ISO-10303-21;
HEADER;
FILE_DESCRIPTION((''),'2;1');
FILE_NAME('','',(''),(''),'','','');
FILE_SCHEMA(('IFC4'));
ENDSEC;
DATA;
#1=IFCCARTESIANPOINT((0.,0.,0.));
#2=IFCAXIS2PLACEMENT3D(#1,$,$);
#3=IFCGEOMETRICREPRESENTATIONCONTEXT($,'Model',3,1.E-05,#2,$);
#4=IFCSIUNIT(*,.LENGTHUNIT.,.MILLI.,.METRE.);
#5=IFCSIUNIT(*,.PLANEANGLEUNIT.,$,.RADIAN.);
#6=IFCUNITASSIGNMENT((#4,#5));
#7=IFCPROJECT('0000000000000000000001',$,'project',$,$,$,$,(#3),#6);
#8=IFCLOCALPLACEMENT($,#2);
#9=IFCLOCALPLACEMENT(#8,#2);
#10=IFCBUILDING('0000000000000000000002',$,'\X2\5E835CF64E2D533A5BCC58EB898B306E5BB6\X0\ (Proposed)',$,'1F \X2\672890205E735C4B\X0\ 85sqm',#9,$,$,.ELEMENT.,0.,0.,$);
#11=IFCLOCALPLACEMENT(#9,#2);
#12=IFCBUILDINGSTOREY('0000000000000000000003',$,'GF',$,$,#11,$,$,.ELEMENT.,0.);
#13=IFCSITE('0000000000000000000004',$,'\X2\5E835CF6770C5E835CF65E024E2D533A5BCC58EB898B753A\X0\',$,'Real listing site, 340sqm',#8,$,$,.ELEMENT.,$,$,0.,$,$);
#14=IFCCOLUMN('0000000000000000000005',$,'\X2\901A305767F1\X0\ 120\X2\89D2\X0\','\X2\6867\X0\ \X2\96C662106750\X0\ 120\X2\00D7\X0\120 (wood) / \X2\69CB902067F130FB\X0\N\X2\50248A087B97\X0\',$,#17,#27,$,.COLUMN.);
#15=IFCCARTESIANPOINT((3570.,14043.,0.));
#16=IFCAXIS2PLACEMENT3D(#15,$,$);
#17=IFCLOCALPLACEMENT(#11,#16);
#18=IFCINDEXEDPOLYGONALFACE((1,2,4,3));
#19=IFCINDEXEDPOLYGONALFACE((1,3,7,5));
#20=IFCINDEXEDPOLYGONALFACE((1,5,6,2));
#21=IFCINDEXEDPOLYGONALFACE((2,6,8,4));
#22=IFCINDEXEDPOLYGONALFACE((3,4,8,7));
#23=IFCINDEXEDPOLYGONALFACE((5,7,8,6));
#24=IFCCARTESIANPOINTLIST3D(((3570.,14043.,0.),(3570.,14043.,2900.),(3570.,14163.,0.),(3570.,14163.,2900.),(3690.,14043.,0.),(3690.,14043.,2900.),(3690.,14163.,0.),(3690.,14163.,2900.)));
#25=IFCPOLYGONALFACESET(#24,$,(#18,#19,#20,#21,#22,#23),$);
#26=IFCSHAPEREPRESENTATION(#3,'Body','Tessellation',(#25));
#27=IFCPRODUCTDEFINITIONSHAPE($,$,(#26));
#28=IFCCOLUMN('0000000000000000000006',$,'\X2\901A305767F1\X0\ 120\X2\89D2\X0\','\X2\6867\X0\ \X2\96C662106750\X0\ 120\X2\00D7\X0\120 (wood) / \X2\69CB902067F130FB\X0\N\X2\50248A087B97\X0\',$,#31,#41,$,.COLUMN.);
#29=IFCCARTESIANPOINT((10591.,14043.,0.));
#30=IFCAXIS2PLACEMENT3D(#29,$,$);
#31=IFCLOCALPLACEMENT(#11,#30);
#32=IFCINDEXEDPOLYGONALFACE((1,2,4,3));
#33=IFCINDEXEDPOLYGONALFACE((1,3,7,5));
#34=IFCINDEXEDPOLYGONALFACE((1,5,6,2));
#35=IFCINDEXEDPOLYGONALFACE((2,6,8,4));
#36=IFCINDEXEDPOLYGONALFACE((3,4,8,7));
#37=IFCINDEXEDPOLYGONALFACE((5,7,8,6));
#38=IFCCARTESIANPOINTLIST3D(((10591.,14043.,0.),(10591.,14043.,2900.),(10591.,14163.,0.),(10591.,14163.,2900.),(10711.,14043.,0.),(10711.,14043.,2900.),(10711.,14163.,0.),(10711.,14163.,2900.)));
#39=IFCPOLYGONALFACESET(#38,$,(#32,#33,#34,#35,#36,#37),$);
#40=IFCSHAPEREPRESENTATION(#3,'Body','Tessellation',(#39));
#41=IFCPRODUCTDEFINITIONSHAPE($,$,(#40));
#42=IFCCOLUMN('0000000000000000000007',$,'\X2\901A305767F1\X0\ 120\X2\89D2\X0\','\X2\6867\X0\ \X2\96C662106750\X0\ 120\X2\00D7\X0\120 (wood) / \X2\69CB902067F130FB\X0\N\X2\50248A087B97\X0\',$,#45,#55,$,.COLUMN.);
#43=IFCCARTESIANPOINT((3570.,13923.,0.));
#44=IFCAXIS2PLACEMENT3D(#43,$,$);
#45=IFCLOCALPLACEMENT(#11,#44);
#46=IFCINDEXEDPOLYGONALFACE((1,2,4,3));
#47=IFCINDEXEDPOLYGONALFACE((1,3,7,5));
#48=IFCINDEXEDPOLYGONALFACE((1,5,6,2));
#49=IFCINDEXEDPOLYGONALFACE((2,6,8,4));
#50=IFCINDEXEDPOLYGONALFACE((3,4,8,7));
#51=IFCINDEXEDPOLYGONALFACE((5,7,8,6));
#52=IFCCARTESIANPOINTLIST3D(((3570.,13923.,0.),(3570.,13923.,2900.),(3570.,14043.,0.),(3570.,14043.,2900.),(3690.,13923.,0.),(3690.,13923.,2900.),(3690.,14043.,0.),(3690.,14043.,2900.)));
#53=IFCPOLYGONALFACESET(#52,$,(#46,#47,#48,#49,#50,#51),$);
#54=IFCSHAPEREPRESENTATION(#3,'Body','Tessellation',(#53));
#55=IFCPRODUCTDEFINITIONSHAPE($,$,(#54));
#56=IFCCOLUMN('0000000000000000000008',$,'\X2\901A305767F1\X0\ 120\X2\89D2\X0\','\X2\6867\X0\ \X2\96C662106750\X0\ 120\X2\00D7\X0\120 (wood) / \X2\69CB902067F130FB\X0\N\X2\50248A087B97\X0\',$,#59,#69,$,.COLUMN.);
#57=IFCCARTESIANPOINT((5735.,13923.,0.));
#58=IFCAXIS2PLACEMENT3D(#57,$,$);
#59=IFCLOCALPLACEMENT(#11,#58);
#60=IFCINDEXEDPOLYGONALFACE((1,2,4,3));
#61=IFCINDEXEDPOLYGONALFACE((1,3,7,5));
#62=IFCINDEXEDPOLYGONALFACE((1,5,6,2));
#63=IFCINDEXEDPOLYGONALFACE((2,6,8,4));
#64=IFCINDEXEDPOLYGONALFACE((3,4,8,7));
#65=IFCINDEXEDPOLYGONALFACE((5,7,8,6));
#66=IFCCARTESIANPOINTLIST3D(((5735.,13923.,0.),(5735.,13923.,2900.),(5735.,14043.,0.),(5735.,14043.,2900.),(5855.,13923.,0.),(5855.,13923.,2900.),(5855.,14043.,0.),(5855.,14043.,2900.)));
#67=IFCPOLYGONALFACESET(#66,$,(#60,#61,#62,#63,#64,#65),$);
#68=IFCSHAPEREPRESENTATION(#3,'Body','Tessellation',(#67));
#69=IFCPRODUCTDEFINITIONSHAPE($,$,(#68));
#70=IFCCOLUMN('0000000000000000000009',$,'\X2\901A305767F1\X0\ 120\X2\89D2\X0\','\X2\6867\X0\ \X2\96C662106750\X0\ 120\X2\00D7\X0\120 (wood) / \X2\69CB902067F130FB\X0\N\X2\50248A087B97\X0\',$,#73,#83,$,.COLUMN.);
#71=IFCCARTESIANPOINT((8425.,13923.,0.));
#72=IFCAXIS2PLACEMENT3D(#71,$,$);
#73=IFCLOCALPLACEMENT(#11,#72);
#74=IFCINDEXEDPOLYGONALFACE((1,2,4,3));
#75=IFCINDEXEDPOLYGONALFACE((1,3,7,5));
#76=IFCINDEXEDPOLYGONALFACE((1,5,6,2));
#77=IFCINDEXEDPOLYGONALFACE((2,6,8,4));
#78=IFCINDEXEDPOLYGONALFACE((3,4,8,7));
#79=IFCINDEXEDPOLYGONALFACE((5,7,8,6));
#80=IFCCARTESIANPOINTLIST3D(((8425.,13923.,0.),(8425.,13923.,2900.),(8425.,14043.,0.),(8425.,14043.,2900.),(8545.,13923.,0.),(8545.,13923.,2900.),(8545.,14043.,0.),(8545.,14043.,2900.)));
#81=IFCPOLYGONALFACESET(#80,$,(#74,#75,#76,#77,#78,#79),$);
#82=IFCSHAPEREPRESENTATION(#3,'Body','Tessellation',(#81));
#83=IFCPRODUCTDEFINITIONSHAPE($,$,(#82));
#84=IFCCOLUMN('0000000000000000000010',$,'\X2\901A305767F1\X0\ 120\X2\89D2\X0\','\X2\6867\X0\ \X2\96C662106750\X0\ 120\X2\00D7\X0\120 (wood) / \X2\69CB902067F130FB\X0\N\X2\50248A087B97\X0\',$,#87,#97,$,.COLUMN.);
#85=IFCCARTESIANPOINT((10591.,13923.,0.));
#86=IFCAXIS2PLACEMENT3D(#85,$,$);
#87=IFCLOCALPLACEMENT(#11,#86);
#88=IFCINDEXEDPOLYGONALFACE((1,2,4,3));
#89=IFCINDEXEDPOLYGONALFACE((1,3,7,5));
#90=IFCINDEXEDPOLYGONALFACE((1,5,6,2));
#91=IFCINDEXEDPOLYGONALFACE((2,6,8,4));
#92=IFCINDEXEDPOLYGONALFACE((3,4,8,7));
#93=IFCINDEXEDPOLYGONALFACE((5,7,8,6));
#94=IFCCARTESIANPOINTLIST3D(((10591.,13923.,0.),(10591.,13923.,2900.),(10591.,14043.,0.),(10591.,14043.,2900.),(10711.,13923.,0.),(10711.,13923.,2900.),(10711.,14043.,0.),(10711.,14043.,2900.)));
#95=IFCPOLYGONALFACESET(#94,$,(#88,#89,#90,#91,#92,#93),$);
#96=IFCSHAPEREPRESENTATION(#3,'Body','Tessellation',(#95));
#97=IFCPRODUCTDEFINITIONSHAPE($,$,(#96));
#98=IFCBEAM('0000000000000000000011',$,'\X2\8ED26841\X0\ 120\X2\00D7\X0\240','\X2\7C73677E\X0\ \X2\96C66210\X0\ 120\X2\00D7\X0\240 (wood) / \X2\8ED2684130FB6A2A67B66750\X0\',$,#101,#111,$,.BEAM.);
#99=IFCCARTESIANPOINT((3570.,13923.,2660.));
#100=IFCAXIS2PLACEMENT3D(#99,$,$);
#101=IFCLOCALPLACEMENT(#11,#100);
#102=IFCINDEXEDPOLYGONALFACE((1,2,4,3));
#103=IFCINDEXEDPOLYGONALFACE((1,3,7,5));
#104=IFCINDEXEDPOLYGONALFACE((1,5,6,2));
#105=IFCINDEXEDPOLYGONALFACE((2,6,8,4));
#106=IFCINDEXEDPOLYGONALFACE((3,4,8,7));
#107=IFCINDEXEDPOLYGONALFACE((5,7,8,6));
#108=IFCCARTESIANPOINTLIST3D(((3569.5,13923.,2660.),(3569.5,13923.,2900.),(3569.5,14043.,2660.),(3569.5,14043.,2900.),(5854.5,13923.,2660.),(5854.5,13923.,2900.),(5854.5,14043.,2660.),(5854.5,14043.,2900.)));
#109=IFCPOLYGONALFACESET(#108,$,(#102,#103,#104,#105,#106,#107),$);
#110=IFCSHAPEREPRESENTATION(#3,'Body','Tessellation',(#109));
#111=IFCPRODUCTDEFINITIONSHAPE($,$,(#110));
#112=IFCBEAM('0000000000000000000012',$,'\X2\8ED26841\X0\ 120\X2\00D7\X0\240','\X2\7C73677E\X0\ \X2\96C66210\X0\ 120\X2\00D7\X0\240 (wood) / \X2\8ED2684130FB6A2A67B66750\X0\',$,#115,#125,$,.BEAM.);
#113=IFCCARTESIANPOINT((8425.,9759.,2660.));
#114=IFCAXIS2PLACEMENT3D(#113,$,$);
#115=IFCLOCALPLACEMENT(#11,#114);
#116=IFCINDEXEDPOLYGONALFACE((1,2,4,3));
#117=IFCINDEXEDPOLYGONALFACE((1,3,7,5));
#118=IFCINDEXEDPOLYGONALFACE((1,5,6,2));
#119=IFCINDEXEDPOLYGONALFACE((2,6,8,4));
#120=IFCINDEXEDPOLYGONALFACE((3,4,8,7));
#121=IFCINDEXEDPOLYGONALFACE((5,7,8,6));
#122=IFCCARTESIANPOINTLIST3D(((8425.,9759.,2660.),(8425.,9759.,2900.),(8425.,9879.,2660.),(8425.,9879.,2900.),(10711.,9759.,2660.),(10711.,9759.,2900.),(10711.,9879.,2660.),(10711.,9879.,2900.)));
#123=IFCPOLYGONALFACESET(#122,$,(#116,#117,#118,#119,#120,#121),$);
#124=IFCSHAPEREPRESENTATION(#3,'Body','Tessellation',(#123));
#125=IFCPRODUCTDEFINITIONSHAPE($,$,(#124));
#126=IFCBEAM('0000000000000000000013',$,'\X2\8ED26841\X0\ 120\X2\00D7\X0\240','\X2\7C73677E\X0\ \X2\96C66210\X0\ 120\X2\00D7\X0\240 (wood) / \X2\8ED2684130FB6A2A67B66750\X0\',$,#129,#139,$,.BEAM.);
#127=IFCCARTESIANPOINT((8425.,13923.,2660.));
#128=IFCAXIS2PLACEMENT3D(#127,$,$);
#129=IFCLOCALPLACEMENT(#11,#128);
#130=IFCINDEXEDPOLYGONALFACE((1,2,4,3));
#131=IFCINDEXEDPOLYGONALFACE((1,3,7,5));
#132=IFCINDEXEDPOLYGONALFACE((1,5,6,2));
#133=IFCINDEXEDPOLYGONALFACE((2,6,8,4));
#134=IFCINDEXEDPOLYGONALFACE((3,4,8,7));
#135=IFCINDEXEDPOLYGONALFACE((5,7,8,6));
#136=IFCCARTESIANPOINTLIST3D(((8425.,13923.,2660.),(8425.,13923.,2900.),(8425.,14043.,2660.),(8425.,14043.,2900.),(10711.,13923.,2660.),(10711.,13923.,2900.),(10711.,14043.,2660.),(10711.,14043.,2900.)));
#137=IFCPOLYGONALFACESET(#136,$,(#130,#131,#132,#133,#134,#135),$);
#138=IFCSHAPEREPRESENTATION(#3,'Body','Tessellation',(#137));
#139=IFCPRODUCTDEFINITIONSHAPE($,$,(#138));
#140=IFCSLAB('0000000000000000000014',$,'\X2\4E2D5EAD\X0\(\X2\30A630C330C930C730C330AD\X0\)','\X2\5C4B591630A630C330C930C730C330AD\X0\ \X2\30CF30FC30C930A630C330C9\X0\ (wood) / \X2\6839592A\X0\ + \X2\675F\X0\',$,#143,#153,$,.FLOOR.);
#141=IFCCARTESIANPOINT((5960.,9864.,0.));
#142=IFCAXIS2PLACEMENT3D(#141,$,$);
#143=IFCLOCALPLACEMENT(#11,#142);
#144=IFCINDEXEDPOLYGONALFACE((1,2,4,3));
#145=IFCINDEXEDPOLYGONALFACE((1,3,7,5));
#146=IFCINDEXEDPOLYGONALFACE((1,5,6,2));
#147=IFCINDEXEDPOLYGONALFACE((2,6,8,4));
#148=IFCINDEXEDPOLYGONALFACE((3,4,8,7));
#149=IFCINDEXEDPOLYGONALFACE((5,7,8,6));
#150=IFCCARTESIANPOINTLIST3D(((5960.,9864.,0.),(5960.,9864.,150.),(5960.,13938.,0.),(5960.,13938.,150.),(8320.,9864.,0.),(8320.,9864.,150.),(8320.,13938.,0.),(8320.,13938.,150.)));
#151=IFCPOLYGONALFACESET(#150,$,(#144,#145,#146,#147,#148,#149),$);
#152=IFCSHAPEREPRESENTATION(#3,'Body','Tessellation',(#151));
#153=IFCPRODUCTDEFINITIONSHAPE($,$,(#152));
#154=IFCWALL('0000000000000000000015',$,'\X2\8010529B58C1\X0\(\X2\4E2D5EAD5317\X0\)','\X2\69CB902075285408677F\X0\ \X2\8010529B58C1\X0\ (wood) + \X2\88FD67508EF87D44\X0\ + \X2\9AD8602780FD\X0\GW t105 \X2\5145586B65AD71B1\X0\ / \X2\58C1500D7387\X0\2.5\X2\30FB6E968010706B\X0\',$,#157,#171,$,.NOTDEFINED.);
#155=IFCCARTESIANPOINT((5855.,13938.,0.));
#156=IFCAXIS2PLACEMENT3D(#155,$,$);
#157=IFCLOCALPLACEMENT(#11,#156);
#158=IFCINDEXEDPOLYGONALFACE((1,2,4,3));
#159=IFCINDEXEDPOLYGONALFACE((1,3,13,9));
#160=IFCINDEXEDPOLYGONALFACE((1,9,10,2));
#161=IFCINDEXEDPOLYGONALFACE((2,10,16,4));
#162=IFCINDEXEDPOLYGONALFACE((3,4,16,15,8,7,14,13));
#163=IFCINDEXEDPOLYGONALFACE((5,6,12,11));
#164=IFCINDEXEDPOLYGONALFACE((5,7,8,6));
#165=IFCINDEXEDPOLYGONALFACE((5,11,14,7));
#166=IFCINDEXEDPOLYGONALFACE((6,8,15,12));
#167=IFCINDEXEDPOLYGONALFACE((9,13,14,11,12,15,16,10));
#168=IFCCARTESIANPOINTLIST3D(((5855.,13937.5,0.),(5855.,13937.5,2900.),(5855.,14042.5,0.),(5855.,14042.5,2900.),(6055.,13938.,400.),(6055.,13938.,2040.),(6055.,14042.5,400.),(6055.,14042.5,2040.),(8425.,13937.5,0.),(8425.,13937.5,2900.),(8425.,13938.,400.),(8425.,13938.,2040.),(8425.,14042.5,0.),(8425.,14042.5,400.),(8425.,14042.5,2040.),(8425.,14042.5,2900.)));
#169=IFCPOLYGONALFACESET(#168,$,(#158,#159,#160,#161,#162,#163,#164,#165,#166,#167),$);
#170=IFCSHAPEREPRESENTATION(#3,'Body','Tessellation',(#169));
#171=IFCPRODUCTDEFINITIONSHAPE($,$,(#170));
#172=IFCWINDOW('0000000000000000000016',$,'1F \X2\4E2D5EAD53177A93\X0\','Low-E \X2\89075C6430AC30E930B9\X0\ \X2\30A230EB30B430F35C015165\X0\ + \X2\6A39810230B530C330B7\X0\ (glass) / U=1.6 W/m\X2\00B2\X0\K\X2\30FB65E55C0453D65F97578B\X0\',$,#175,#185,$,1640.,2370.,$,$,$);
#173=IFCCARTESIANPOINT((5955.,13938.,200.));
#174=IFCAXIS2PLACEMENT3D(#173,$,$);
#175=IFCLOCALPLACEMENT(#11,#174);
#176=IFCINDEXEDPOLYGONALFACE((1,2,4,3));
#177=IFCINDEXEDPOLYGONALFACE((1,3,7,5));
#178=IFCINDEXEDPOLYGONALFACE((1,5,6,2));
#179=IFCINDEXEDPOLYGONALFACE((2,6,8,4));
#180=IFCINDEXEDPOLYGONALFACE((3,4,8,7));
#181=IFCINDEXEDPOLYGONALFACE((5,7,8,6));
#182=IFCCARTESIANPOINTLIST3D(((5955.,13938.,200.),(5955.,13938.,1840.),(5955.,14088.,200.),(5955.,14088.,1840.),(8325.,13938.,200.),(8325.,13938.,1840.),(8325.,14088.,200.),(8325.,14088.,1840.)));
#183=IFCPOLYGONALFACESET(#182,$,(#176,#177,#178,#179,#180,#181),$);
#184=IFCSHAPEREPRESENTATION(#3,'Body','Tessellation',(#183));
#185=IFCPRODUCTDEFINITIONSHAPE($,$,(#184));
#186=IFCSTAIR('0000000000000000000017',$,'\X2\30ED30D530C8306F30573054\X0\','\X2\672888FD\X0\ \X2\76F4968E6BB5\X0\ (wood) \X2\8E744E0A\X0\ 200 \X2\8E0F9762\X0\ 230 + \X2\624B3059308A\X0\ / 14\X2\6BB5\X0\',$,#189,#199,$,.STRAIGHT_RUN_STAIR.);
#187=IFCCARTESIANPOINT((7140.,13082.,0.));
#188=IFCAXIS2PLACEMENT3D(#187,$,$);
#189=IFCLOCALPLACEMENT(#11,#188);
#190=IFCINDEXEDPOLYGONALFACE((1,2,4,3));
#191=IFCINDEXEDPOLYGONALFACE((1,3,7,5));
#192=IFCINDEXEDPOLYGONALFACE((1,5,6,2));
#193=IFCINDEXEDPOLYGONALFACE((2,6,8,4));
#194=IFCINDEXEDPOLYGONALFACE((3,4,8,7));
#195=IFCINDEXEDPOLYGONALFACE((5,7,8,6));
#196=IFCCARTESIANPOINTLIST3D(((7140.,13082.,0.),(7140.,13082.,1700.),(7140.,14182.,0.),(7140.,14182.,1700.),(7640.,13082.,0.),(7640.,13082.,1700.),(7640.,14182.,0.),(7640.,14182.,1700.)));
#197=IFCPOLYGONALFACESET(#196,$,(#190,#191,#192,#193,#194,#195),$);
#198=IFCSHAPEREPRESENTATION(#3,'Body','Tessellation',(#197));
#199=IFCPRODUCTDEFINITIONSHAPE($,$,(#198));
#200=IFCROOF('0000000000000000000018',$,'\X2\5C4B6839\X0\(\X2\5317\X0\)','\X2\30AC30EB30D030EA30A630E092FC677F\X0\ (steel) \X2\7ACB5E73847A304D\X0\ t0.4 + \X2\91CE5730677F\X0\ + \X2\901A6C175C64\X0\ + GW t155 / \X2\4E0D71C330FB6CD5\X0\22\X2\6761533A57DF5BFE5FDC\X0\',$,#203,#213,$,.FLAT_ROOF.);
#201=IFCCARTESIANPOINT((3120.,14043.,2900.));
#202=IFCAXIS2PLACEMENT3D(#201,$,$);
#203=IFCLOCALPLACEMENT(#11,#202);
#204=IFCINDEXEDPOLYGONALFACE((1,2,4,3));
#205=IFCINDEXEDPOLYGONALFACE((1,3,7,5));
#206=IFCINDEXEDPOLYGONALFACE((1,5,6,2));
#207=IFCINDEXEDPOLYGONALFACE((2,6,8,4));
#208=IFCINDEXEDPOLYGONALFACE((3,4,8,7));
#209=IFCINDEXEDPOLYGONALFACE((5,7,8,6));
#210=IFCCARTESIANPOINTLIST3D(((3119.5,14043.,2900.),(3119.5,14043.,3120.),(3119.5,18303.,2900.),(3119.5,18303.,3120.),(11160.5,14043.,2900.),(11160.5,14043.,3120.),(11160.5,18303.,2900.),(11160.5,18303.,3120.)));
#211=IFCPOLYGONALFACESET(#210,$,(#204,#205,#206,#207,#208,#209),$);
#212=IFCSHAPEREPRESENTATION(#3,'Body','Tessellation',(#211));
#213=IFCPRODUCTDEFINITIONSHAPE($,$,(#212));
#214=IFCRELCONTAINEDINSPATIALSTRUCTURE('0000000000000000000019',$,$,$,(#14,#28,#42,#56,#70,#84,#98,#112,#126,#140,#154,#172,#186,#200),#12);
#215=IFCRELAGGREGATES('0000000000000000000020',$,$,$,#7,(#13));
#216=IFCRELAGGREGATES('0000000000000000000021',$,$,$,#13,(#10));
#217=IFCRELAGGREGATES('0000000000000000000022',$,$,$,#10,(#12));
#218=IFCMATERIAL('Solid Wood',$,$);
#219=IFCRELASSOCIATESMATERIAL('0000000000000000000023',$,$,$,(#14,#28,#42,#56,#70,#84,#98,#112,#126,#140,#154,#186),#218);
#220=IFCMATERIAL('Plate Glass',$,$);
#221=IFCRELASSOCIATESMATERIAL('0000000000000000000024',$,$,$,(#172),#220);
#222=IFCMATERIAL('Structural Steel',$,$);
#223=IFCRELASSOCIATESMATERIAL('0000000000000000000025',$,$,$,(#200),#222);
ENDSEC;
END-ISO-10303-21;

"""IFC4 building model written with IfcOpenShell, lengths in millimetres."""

from ifc_helpers import new_model, si_unit, frame, frame_2d, origin, place, context, project, spatial, rectangle, extrude, material, element, fill, save


model = new_model("IFC4")

# Units and contexts
model_context = context("Model", 3, precision=1e-05, world=origin())
ifc_project = project(units=[si_unit("LENGTHUNIT", "METRE", prefix="MILLI"), si_unit("PLANEANGLEUNIT", "RADIAN")], contexts=[model_context])

# Site, building, storey
site_placement = place(None, origin())
site = spatial("IfcSite", under=ifc_project, at=site_placement, Name="広島県広島市中区富士見町", ObjectType="Real listing site, 340sqm", CompositionType="ELEMENT", RefElevation=0.0)
building_placement = place(site_placement, origin())
building = spatial("IfcBuilding", under=site, at=building_placement, Name="広島中区富士見の家 (Proposed)", ObjectType="1F 木造平屋 85sqm", CompositionType="ELEMENT", ElevationOfRefHeight=0.0, ElevationOfTerrain=0.0)
storey_placement = place(building_placement, origin())
storey = spatial("IfcBuildingStorey", under=building, at=storey_placement, Name="GF", CompositionType="ELEMENT", Elevation=0.0)

# Columns
ifc_material_1 = material(Name="Solid Wood")
column_1_placement = place(storey_placement, frame((3570.0, 14043.0, 0.0)))
element("IfcColumn", 1, at=column_1_placement, inside=storey, material=ifc_material_1, Name="通し柱 120角", Description="桧 集成材 120×120 (wood) / 構造柱・N値計算", PredefinedType="COLUMN", context=model_context, shape_type="SweptSolid", body=[
    extrude(rectangle(XDim=120.0, YDim=120.0, at=frame_2d((60.0, 60.0))), frame((3570.0, 14043.0, 0.0)), (0.0, 0.0, 1.0), 2900.0),
])
column_2_placement = place(storey_placement, frame((10591.0, 14043.0, 0.0)))
element("IfcColumn", 2, at=column_2_placement, inside=storey, material=ifc_material_1, Name="通し柱 120角", Description="桧 集成材 120×120 (wood) / 構造柱・N値計算", PredefinedType="COLUMN", context=model_context, shape_type="SweptSolid", body=[
    extrude(rectangle(XDim=120.0, YDim=120.0, at=frame_2d((60.0, 60.0))), frame((10591.0, 14043.0, 0.0)), (0.0, 0.0, 1.0), 2900.0),
])
column_3_placement = place(storey_placement, frame((3570.0, 13923.0, 0.0)))
element("IfcColumn", 3, at=column_3_placement, inside=storey, material=ifc_material_1, Name="通し柱 120角", Description="桧 集成材 120×120 (wood) / 構造柱・N値計算", PredefinedType="COLUMN", context=model_context, shape_type="SweptSolid", body=[
    extrude(rectangle(XDim=120.0, YDim=120.0, at=frame_2d((60.0, 60.0))), frame((3570.0, 13923.0, 0.0)), (0.0, 0.0, 1.0), 2900.0),
])
column_4_placement = place(storey_placement, frame((5735.0, 13923.0, 0.0)))
element("IfcColumn", 4, at=column_4_placement, inside=storey, material=ifc_material_1, Name="通し柱 120角", Description="桧 集成材 120×120 (wood) / 構造柱・N値計算", PredefinedType="COLUMN", context=model_context, shape_type="SweptSolid", body=[
    extrude(rectangle(XDim=120.0, YDim=120.0, at=frame_2d((60.0, 60.0))), frame((5735.0, 13923.0, 0.0)), (0.0, 0.0, 1.0), 2900.0),
])
column_5_placement = place(storey_placement, frame((8425.0, 13923.0, 0.0)))
element("IfcColumn", 5, at=column_5_placement, inside=storey, material=ifc_material_1, Name="通し柱 120角", Description="桧 集成材 120×120 (wood) / 構造柱・N値計算", PredefinedType="COLUMN", context=model_context, shape_type="SweptSolid", body=[
    extrude(rectangle(XDim=120.0, YDim=120.0, at=frame_2d((60.0, 60.0))), frame((8425.0, 13923.0, 0.0)), (0.0, 0.0, 1.0), 2900.0),
])
column_6_placement = place(storey_placement, frame((10591.0, 13923.0, 0.0)))
element("IfcColumn", 6, at=column_6_placement, inside=storey, material=ifc_material_1, Name="通し柱 120角", Description="桧 集成材 120×120 (wood) / 構造柱・N値計算", PredefinedType="COLUMN", context=model_context, shape_type="SweptSolid", body=[
    extrude(rectangle(XDim=120.0, YDim=120.0, at=frame_2d((60.0, 60.0))), frame((10591.0, 13923.0, 0.0)), (0.0, 0.0, 1.0), 2900.0),
])

# Beams
beam_1_placement = place(storey_placement, frame((3570.0, 13923.0, 2660.0)))
element("IfcBeam", 7, at=beam_1_placement, inside=storey, material=ifc_material_1, Name="軒桁 120×240", Description="米松 集成 120×240 (wood) / 軒桁・横架材", PredefinedType="BEAM", context=model_context, shape_type="SweptSolid", body=[
    extrude(rectangle(XDim=2285.0, YDim=120.0, at=frame_2d((1142.0, 60.0))), frame((3570.0, 13923.0, 2660.0)), (0.0, 0.0, 1.0), 240.0),
])
beam_2_placement = place(storey_placement, frame((8425.0, 9759.0, 2660.0)))
element("IfcBeam", 8, at=beam_2_placement, inside=storey, material=ifc_material_1, Name="軒桁 120×240", Description="米松 集成 120×240 (wood) / 軒桁・横架材", PredefinedType="BEAM", context=model_context, shape_type="SweptSolid", body=[
    extrude(rectangle(XDim=2286.0, YDim=120.0, at=frame_2d((1143.0, 60.0))), frame((8425.0, 9759.0, 2660.0)), (0.0, 0.0, 1.0), 240.0),
])
beam_3_placement = place(storey_placement, frame((8425.0, 13923.0, 2660.0)))
element("IfcBeam", 9, at=beam_3_placement, inside=storey, material=ifc_material_1, Name="軒桁 120×240", Description="米松 集成 120×240 (wood) / 軒桁・横架材", PredefinedType="BEAM", context=model_context, shape_type="SweptSolid", body=[
    extrude(rectangle(XDim=2286.0, YDim=120.0, at=frame_2d((1143.0, 60.0))), frame((8425.0, 13923.0, 2660.0)), (0.0, 0.0, 1.0), 240.0),
])

# Slab
slab_1_placement = place(storey_placement, frame((5960.0, 9864.0, 0.0)))
element("IfcSlab", 10, at=slab_1_placement, inside=storey, material=ifc_material_1, Name="中庭(ウッドデッキ)", Description="屋外ウッドデッキ ハードウッド (wood) / 根太 + 束", PredefinedType="FLOOR", context=model_context, shape_type="SweptSolid", body=[
    extrude(rectangle(XDim=2360.0, YDim=4074.0, at=frame_2d((1180.0, 2037.0))), frame((5960.0, 9864.0, 0.0)), (0.0, 0.0, 1.0), 150.0),
])

# Wall, opening, window
wall_placement = place(storey_placement, frame((5855.0, 13938.0, 0.0)))
wall = element("IfcWall", 11, at=wall_placement, inside=storey, material=ifc_material_1, Name="耐力壁(中庭北)", Description="構造用合板 耐力壁 (wood) + 製材軸組 + 高性能GW t105 充填断熱 / 壁倍率2.5・準耐火", PredefinedType="NOTDEFINED", context=model_context, shape_type="SweptSolid", body=[
    extrude(rectangle(XDim=2570.0, YDim=105.0, at=frame_2d((1285.0, 52.0))), frame((5855.0, 13938.0, 0.0)), (0.0, 0.0, 1.0), 2900.0),
])
opening_placement = place(storey_placement, frame((5955.0, 13938.0, 200.0)))
opening = element("IfcOpeningElement", 12, at=opening_placement, cuts=wall, PredefinedType="NOTDEFINED", context=model_context, shape_type="SweptSolid", body=[
    extrude(rectangle(XDim=2370.0, YDim=150.0, at=frame_2d((1185.0, 75.0))), frame((5955.0, 13938.0, 200.0)), (0.0, 0.0, 1.0), 1640.0),
])
ifc_material_2 = material(Name="Plate Glass")
window_placement = place(storey_placement, frame((5955.0, 13938.0, 200.0)))
window = element("IfcWindow", 13, at=window_placement, inside=storey, material=ifc_material_2, Name="1F 中庭北窓", Description="Low-E 複層ガラス アルゴン封入 + 樹脂サッシ (glass) / U=1.6 W/m²K・日射取得型", OverallHeight=1640.0, OverallWidth=2370.0, context=model_context, shape_type="SweptSolid", body=[
    extrude(rectangle(XDim=2370.0, YDim=150.0, at=frame_2d((1185.0, 75.0))), frame((5955.0, 13938.0, 200.0)), (0.0, 0.0, 1.0), 1640.0),
])
fill(opening, window)

# Stair
stair_placement = place(storey_placement, frame((7140.0, 13082.0, 0.0)))
element("IfcStair", 14, at=stair_placement, inside=storey, material=ifc_material_1, Name="ロフトはしご", Description="木製 直階段 (wood) 蹴上 200 踏面 230 + 手すり / 14段", PredefinedType="STRAIGHT_RUN_STAIR", context=model_context, shape_type="SweptSolid", body=[
    extrude(rectangle(XDim=500.0, YDim=1100.0, at=frame_2d((250.0, 550.0))), frame((7140.0, 13082.0, 0.0)), (0.0, 0.0, 1.0), 1700.0),
])

# Roof
ifc_material_3 = material(Name="Structural Steel")
roof_placement = place(storey_placement, frame((3120.0, 14043.0, 2900.0)))
element("IfcRoof", 15, at=roof_placement, inside=storey, material=ifc_material_3, Name="屋根(北)", Description="ガルバリウム鋼板 (steel) 立平葺き t0.4 + 野地板 + 通気層 + GW t155 / 不燃・法22条区域対応", PredefinedType="FLAT_ROOF", context=model_context, shape_type="SweptSolid", body=[
    extrude(rectangle(XDim=8041.0, YDim=4260.0, at=frame_2d((4020.0, 2130.0))), frame((3120.0, 14043.0, 2900.0)), (0.0, 0.0, 1.0), 220.0),
])

save(model, "model.ifc")
